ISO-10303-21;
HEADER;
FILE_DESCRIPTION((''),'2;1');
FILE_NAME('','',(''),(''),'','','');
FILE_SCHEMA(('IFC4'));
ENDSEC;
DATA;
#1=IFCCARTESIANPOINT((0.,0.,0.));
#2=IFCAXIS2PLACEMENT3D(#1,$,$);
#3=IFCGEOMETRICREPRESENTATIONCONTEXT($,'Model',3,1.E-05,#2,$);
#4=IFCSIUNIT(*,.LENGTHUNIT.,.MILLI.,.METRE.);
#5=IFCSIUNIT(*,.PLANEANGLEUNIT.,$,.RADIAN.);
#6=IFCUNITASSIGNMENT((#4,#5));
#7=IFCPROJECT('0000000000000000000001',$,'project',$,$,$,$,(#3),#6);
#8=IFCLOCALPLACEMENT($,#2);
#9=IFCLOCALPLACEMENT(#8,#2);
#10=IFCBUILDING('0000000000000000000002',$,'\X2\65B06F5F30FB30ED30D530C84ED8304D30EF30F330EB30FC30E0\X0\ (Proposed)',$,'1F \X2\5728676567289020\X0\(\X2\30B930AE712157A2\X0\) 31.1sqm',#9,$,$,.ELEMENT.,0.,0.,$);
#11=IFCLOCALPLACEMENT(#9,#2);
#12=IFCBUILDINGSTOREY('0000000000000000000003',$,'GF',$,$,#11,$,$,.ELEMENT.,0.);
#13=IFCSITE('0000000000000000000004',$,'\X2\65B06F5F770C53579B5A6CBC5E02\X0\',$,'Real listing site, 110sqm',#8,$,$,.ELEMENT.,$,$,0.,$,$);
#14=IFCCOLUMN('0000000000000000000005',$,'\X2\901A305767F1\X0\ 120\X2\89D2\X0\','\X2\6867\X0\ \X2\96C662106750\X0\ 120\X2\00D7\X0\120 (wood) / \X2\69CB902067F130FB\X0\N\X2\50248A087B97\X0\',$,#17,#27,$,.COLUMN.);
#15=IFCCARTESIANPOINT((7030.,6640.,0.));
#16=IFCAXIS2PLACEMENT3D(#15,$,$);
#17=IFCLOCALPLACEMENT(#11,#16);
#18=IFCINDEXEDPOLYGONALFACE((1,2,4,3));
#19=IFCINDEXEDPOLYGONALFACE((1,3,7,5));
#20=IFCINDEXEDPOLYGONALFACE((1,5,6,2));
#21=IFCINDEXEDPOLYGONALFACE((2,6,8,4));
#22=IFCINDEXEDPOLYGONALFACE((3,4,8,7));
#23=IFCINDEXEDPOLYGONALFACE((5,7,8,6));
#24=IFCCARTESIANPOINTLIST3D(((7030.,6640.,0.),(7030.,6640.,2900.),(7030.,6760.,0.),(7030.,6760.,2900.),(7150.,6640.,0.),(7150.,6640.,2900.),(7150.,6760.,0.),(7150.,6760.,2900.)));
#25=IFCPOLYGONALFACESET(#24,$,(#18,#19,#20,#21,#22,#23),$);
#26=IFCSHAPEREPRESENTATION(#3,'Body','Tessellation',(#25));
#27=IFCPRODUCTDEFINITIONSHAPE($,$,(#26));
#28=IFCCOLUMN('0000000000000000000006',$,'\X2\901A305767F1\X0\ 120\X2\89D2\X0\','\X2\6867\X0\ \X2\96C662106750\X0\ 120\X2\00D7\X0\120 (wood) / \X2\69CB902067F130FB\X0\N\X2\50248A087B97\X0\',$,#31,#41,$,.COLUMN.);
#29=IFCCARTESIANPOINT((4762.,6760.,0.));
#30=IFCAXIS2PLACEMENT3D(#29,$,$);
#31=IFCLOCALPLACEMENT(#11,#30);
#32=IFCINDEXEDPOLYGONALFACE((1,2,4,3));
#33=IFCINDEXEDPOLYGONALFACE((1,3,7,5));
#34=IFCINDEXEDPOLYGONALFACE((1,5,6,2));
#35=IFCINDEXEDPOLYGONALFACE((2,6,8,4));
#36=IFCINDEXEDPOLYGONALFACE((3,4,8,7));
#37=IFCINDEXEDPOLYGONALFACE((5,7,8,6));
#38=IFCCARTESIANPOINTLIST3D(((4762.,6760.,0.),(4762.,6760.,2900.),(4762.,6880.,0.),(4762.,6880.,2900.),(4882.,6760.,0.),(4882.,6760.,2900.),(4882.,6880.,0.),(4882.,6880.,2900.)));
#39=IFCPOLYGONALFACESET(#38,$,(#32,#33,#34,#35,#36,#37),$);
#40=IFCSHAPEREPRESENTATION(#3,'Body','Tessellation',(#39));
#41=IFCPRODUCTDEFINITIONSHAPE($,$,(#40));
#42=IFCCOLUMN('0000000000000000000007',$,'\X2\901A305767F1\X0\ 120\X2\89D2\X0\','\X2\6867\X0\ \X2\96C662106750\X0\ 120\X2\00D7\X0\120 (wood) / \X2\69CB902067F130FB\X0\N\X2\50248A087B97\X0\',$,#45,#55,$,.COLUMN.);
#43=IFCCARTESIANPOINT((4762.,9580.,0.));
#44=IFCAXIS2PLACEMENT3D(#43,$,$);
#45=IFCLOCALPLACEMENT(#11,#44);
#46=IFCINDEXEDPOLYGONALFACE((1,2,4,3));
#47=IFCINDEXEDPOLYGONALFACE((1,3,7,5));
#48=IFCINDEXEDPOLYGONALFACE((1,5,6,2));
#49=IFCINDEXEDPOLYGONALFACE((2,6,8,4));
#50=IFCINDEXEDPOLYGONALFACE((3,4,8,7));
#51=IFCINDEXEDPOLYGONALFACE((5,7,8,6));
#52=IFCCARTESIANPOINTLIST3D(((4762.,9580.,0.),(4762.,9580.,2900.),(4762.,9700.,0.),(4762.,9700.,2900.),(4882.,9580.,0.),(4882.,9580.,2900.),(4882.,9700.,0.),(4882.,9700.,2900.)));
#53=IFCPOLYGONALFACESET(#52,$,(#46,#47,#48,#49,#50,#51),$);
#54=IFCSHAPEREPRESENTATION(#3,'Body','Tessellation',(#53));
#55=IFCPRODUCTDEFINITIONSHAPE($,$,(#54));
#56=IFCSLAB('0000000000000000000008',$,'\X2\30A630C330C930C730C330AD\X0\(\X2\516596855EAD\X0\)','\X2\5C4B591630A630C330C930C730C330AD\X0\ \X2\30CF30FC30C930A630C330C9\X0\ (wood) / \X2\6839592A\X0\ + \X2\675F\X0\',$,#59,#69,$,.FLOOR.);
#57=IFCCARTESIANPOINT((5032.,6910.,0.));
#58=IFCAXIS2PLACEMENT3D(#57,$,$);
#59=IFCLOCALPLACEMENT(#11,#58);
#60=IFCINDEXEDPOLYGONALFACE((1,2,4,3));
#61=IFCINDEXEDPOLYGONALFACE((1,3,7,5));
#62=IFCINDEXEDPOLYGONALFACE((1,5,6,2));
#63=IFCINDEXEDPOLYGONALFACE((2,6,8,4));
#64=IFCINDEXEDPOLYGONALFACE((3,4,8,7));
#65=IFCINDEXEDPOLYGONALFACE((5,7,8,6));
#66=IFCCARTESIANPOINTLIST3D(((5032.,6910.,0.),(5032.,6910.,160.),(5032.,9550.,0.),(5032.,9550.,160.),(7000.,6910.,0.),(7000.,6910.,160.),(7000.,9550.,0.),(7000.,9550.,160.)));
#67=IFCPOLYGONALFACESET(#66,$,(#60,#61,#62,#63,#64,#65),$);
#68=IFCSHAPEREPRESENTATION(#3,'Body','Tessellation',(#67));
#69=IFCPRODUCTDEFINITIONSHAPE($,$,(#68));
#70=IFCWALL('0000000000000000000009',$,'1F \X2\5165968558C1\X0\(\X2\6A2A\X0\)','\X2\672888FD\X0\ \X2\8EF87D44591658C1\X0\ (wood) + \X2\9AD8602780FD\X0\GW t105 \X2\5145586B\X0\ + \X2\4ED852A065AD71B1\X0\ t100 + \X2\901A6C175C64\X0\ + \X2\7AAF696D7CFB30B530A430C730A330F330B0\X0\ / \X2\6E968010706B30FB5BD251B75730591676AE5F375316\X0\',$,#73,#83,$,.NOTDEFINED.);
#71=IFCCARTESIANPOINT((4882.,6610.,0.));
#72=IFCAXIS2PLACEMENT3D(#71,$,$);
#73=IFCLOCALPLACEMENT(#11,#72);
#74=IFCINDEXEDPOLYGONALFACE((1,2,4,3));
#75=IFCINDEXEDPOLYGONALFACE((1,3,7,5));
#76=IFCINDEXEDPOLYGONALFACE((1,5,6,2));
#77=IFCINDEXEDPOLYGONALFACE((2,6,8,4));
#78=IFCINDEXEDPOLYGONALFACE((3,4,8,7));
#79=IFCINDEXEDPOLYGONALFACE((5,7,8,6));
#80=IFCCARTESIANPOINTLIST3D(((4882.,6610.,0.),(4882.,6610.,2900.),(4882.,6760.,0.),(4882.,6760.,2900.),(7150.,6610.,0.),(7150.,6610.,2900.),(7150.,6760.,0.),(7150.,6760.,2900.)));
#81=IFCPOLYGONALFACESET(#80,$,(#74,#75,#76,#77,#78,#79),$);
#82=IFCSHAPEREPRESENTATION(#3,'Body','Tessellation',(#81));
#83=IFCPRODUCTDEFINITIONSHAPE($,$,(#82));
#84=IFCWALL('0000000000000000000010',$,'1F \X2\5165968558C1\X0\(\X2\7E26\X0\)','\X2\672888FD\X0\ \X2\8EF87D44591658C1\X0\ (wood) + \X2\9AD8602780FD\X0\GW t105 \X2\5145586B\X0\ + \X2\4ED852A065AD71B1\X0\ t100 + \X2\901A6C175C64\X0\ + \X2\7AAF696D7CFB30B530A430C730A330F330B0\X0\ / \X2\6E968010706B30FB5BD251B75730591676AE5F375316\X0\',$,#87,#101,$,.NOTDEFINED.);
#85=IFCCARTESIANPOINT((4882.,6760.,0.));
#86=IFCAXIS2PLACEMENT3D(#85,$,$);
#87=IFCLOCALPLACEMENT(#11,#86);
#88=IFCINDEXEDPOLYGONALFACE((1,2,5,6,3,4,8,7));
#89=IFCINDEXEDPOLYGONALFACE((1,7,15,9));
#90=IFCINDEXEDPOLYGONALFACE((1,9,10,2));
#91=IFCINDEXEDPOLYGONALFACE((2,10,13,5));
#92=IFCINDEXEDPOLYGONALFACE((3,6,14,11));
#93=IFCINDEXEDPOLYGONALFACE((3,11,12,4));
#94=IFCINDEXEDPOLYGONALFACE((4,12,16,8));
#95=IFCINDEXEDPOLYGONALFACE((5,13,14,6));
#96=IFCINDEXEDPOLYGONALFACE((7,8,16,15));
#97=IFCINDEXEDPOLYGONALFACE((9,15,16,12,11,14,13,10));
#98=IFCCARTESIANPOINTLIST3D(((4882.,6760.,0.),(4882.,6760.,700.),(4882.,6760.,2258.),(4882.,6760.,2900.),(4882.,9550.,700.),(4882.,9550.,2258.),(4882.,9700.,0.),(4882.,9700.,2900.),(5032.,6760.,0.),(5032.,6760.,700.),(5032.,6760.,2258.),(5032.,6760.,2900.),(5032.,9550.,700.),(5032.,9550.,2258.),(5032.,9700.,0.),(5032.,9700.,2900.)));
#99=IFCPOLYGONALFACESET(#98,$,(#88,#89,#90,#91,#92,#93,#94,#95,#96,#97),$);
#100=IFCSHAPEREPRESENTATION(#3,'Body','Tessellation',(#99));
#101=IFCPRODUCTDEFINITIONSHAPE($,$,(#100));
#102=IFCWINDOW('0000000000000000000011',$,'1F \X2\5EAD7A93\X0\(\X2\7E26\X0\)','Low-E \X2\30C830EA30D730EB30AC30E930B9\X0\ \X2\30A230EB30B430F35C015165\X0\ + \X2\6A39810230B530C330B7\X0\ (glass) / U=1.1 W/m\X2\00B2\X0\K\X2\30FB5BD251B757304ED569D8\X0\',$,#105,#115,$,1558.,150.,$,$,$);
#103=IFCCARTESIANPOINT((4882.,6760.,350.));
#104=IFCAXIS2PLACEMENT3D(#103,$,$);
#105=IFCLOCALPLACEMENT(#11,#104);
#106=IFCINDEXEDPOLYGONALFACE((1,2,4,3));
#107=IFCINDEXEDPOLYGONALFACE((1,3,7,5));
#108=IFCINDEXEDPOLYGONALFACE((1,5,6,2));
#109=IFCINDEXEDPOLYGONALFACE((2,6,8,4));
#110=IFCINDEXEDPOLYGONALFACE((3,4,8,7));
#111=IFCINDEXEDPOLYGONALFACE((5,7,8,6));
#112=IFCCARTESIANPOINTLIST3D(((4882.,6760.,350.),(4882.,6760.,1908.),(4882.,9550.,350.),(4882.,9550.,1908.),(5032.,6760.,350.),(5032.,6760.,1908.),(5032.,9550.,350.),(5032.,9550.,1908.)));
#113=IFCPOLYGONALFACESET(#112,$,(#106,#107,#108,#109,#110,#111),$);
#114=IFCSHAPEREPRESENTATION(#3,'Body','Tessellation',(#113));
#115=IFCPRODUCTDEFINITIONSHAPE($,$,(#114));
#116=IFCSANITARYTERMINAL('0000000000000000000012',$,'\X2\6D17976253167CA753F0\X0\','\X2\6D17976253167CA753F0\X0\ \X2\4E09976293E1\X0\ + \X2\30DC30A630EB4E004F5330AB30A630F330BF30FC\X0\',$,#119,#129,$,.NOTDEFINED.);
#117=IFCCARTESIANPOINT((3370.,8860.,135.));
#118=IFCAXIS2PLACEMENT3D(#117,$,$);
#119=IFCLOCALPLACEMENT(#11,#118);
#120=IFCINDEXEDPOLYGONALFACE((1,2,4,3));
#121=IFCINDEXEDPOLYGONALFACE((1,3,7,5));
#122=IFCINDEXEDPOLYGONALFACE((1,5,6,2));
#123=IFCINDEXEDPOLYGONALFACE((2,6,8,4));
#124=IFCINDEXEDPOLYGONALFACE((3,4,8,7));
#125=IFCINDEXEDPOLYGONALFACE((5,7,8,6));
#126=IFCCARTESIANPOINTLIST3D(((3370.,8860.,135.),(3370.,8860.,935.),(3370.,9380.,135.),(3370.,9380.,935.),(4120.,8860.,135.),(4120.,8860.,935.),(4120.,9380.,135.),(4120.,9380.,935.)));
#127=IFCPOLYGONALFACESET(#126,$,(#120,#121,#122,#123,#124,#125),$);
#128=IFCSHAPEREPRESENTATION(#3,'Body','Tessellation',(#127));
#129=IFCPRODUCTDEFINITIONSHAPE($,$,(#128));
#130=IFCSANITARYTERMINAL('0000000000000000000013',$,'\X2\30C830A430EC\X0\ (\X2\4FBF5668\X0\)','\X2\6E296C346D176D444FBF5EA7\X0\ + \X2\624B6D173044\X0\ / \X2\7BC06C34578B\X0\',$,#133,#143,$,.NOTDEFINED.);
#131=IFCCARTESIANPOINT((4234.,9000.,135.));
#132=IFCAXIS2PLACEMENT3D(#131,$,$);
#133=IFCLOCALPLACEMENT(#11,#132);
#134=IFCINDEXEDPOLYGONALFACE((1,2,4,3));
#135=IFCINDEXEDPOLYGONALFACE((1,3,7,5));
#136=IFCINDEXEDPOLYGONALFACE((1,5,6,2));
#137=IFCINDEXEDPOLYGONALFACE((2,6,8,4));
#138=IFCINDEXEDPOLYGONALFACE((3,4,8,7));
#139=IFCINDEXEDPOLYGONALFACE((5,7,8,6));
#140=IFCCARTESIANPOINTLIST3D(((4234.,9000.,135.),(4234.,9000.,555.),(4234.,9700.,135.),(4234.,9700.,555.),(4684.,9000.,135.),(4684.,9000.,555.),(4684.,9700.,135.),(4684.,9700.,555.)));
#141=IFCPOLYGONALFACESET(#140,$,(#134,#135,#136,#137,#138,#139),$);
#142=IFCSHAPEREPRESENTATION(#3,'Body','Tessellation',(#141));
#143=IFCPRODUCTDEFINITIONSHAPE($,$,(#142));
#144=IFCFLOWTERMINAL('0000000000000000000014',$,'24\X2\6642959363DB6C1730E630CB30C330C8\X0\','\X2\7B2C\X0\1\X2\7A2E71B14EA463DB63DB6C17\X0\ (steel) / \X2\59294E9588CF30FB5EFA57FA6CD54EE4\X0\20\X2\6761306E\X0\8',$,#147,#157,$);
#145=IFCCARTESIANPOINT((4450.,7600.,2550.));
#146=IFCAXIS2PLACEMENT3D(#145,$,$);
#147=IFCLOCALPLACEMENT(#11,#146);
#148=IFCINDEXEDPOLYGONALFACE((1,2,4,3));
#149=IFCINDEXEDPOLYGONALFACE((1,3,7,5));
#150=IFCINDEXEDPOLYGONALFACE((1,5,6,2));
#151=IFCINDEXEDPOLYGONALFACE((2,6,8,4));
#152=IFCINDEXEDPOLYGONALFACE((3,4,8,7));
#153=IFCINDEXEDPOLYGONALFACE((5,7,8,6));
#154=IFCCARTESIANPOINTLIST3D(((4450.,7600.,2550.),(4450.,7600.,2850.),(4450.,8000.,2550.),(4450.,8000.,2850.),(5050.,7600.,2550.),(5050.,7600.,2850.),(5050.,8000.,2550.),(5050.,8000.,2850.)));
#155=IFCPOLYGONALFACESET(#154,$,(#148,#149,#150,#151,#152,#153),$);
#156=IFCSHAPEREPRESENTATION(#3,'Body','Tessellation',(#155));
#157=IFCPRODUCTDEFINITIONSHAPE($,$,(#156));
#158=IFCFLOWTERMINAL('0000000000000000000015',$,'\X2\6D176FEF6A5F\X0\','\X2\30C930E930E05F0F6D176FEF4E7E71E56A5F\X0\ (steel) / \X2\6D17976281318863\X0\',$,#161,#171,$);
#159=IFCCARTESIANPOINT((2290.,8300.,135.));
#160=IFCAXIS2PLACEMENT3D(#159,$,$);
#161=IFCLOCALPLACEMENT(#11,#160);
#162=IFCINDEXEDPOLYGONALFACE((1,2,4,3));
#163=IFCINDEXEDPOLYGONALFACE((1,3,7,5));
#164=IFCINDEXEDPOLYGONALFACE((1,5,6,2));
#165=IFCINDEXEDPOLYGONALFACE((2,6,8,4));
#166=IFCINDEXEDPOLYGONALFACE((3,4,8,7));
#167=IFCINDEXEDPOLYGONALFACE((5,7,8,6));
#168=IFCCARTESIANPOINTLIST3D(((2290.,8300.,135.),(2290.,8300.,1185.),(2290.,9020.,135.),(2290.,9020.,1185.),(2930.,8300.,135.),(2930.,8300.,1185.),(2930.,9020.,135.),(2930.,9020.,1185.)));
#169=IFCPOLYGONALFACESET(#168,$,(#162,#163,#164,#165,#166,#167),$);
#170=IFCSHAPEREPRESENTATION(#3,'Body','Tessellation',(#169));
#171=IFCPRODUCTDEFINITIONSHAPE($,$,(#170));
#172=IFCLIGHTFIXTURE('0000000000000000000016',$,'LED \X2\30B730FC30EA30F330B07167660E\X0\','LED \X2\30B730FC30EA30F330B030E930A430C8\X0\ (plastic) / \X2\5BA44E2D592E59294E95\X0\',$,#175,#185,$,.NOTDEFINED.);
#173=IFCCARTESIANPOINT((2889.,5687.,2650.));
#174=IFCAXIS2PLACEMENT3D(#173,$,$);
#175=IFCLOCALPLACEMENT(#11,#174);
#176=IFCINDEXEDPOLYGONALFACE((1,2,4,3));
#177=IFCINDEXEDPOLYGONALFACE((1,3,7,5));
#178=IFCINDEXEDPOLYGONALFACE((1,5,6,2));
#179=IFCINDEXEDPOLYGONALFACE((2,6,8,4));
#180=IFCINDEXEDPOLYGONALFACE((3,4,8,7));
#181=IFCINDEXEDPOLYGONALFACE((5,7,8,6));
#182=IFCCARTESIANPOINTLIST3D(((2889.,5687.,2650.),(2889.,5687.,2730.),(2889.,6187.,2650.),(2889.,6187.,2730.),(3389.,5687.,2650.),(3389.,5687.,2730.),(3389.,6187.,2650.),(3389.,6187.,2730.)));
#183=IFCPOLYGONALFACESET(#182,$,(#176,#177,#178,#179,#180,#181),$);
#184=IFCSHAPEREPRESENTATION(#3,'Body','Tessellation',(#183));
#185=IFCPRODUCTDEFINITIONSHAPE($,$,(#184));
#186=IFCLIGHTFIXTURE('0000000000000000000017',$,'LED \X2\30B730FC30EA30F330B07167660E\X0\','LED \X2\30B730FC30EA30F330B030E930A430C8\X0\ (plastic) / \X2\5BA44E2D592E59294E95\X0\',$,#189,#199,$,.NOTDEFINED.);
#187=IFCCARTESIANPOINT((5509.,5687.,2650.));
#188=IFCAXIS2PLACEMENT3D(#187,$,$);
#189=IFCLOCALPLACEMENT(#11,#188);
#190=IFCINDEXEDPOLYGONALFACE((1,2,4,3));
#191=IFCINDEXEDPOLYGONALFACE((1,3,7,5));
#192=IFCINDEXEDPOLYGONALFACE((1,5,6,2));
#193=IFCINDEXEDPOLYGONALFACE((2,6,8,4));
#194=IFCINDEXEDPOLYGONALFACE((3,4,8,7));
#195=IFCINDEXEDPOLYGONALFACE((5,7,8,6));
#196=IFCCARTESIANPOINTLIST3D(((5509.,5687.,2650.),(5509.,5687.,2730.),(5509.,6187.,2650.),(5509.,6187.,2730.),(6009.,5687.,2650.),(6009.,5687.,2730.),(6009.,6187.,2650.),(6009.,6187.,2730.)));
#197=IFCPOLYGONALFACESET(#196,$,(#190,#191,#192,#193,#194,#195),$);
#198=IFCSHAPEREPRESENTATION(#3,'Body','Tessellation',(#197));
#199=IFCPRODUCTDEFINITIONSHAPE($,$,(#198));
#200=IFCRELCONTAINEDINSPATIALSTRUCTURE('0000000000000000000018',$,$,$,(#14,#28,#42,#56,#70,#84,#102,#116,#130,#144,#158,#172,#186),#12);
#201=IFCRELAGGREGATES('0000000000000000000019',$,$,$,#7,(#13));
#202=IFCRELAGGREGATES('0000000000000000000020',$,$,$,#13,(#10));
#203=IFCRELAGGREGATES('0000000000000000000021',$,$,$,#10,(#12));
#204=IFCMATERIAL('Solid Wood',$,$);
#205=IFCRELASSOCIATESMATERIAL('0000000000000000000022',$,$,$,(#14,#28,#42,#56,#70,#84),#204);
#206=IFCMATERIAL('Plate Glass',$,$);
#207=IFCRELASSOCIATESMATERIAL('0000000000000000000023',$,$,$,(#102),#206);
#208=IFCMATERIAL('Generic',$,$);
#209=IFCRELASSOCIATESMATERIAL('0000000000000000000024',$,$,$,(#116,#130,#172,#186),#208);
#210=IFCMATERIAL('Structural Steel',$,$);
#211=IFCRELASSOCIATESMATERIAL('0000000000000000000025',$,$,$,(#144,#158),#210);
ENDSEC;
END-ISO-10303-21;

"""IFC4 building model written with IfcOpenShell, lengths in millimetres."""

from ifc_helpers import new_model, si_unit, frame, frame_2d, origin, place, context, project, spatial, rectangle, extrude, material, element, fill, save


model = new_model("IFC4")

# Units and contexts
model_context = context("Model", 3, precision=1e-05, world=origin())
ifc_project = project(units=[si_unit("LENGTHUNIT", "METRE", prefix="MILLI"), si_unit("PLANEANGLEUNIT", "RADIAN")], contexts=[model_context])

# Site, building, storey
site_placement = place(None, origin())
site = spatial("IfcSite", under=ifc_project, at=site_placement, Name="新潟県南魚沼市", ObjectType="Real listing site, 110sqm", CompositionType="ELEMENT", RefElevation=0.0)
building_placement = place(site_placement, origin())
building = spatial("IfcBuilding", under=site, at=building_placement, Name="新潟・ロフト付きワンルーム (Proposed)", ObjectType="1F 在来木造(スギ無垢) 31.1sqm", CompositionType="ELEMENT", ElevationOfRefHeight=0.0, ElevationOfTerrain=0.0)
storey_placement = place(building_placement, origin())
storey = spatial("IfcBuildingStorey", under=building, at=storey_placement, Name="GF", CompositionType="ELEMENT", Elevation=0.0)

# Columns
ifc_material_1 = material(Name="Solid Wood")
column_1_placement = place(storey_placement, frame((7030.0, 6640.0, 0.0)))
element("IfcColumn", 1, at=column_1_placement, inside=storey, material=ifc_material_1, Name="通し柱 120角", Description="桧 集成材 120×120 (wood) / 構造柱・N値計算", PredefinedType="COLUMN", context=model_context, shape_type="SweptSolid", body=[
    extrude(rectangle(XDim=120.0, YDim=120.0, at=frame_2d((60.0, 60.0))), frame((7030.0, 6640.0, 0.0)), (0.0, 0.0, 1.0), 2900.0),
])
column_2_placement = place(storey_placement, frame((4762.0, 6760.0, 0.0)))
element("IfcColumn", 2, at=column_2_placement, inside=storey, material=ifc_material_1, Name="通し柱 120角", Description="桧 集成材 120×120 (wood) / 構造柱・N値計算", PredefinedType="COLUMN", context=model_context, shape_type="SweptSolid", body=[
    extrude(rectangle(XDim=120.0, YDim=120.0, at=frame_2d((60.0, 60.0))), frame((4762.0, 6760.0, 0.0)), (0.0, 0.0, 1.0), 2900.0),
])
column_3_placement = place(storey_placement, frame((4762.0, 9580.0, 0.0)))
element("IfcColumn", 3, at=column_3_placement, inside=storey, material=ifc_material_1, Name="通し柱 120角", Description="桧 集成材 120×120 (wood) / 構造柱・N値計算", PredefinedType="COLUMN", context=model_context, shape_type="SweptSolid", body=[
    extrude(rectangle(XDim=120.0, YDim=120.0, at=frame_2d((60.0, 60.0))), frame((4762.0, 9580.0, 0.0)), (0.0, 0.0, 1.0), 2900.0),
])

# Slab
slab_placement = place(storey_placement, frame((5032.0, 6910.0, 0.0)))
element("IfcSlab", 4, at=slab_placement, inside=storey, material=ifc_material_1, Name="ウッドデッキ(入隅庭)", Description="屋外ウッドデッキ ハードウッド (wood) / 根太 + 束", PredefinedType="FLOOR", context=model_context, shape_type="SweptSolid", body=[
    extrude(rectangle(XDim=1968.0, YDim=2640.0, at=frame_2d((984.0, 1320.0))), frame((5032.0, 6910.0, 0.0)), (0.0, 0.0, 1.0), 160.0),
])

# Wall
wall_1_placement = place(storey_placement, frame((4882.0, 6610.0, 0.0)))
element("IfcWall", 5, at=wall_1_placement, inside=storey, material=ifc_material_1, Name="1F 入隅壁(横)", Description="木製 軸組外壁 (wood) + 高性能GW t105 充填 + 付加断熱 t100 + 通気層 + 窯業系サイディング / 準耐火・寒冷地外皮強化", PredefinedType="NOTDEFINED", context=model_context, shape_type="SweptSolid", body=[
    extrude(rectangle(XDim=2268.0, YDim=150.0, at=frame_2d((1134.0, 75.0))), frame((4882.0, 6610.0, 0.0)), (0.0, 0.0, 1.0), 2900.0),
])

# Wall, opening, window
wall_2_placement = place(storey_placement, frame((4882.0, 6760.0, 0.0)))
wall_2 = element("IfcWall", 6, at=wall_2_placement, inside=storey, material=ifc_material_1, Name="1F 入隅壁(縦)", Description="木製 軸組外壁 (wood) + 高性能GW t105 充填 + 付加断熱 t100 + 通気層 + 窯業系サイディング / 準耐火・寒冷地外皮強化", PredefinedType="NOTDEFINED", context=model_context, shape_type="SweptSolid", body=[
    extrude(rectangle(XDim=150.0, YDim=2940.0, at=frame_2d((75.0, 1470.0))), frame((4882.0, 6760.0, 0.0)), (0.0, 0.0, 1.0), 2900.0),
])
opening_placement = place(storey_placement, frame((4882.0, 6760.0, 350.0)))
opening = element("IfcOpeningElement", 7, at=opening_placement, cuts=wall_2, PredefinedType="NOTDEFINED", context=model_context, shape_type="SweptSolid", body=[
    extrude(rectangle(XDim=150.0, YDim=2790.0, at=frame_2d((75.0, 1395.0))), frame((4882.0, 6760.0, 350.0)), (0.0, 0.0, 1.0), 1558.0),
])
ifc_material_2 = material(Name="Plate Glass")
window_placement = place(storey_placement, frame((4882.0, 6760.0, 350.0)))
window = element("IfcWindow", 8, at=window_placement, inside=storey, material=ifc_material_2, Name="1F 庭窓(縦)", Description="Low-E トリプルガラス アルゴン封入 + 樹脂サッシ (glass) / U=1.1 W/m²K・寒冷地仕様", OverallHeight=1558.0, OverallWidth=150.0, context=model_context, shape_type="SweptSolid", body=[
    extrude(rectangle(XDim=150.0, YDim=2790.0, at=frame_2d((75.0, 1395.0))), frame((4882.0, 6760.0, 350.0)), (0.0, 0.0, 1.0), 1558.0),
])
fill(opening, window)

# Sanitary terminals
ifc_material_3 = material(Name="Generic")
sanitary_terminal_1_placement = place(storey_placement, frame((3370.0, 8860.0, 135.0)))
element("IfcSanitaryTerminal", 9, at=sanitary_terminal_1_placement, inside=storey, material=ifc_material_3, Name="洗面化粧台", Description="洗面化粧台 三面鏡 + ボウル一体カウンター", PredefinedType="NOTDEFINED", context=model_context, shape_type="SweptSolid", body=[
    extrude(rectangle(XDim=750.0, YDim=520.0, at=frame_2d((375.0, 260.0))), frame((3370.0, 8860.0, 135.0)), (0.0, 0.0, 1.0), 800.0),
])
sanitary_terminal_2_placement = place(storey_placement, frame((4234.0, 9000.0, 135.0)))
element("IfcSanitaryTerminal", 10, at=sanitary_terminal_2_placement, inside=storey, material=ifc_material_3, Name="トイレ (便器)", Description="温水洗浄便座 + 手洗い / 節水型", PredefinedType="NOTDEFINED", context=model_context, shape_type="SweptSolid", body=[
    extrude(rectangle(XDim=450.0, YDim=700.0, at=frame_2d((225.0, 350.0))), frame((4234.0, 9000.0, 135.0)), (0.0, 0.0, 1.0), 420.0),
])

# Flow terminals
ifc_material_4 = material(Name="Structural Steel")
flow_terminal_1_placement = place(storey_placement, frame((4450.0, 7600.0, 2550.0)))
element("IfcFlowTerminal", 11, at=flow_terminal_1_placement, inside=storey, material=ifc_material_4, Name="24時間換気ユニット", Description="第1種熱交換換気 (steel) / 天井裏・建基法令20条の8", context=model_context, shape_type="SweptSolid", body=[
    extrude(rectangle(XDim=600.0, YDim=400.0, at=frame_2d((300.0, 200.0))), frame((4450.0, 7600.0, 2550.0)), (0.0, 0.0, 1.0), 300.0),
])
flow_terminal_2_placement = place(storey_placement, frame((2290.0, 8300.0, 135.0)))
element("IfcFlowTerminal", 12, at=flow_terminal_2_placement, inside=storey, material=ifc_material_4, Name="洗濯機", Description="ドラム式洗濯乾燥機 (steel) / 洗面脱衣", context=model_context, shape_type="SweptSolid", body=[
    extrude(rectangle(XDim=640.0, YDim=720.0, at=frame_2d((320.0, 360.0))), frame((2290.0, 8300.0, 135.0)), (0.0, 0.0, 1.0), 1050.0),
])

# Light fixtures
light_fixture_1_placement = place(storey_placement, frame((2889.0, 5687.0, 2650.0)))
element("IfcLightFixture", 13, at=light_fixture_1_placement, inside=storey, material=ifc_material_3, Name="LED シーリング照明", Description="LED シーリングライト (plastic) / 室中央天井", PredefinedType="NOTDEFINED", context=model_context, shape_type="SweptSolid", body=[
    extrude(rectangle(XDim=500.0, YDim=500.0, at=frame_2d((250.0, 250.0))), frame((2889.0, 5687.0, 2650.0)), (0.0, 0.0, 1.0), 80.0),
])
light_fixture_2_placement = place(storey_placement, frame((5509.0, 5687.0, 2650.0)))
element("IfcLightFixture", 14, at=light_fixture_2_placement, inside=storey, material=ifc_material_3, Name="LED シーリング照明", Description="LED シーリングライト (plastic) / 室中央天井", PredefinedType="NOTDEFINED", context=model_context, shape_type="SweptSolid", body=[
    extrude(rectangle(XDim=500.0, YDim=500.0, at=frame_2d((250.0, 250.0))), frame((5509.0, 5687.0, 2650.0)), (0.0, 0.0, 1.0), 80.0),
])

save(model, "model.ifc")
